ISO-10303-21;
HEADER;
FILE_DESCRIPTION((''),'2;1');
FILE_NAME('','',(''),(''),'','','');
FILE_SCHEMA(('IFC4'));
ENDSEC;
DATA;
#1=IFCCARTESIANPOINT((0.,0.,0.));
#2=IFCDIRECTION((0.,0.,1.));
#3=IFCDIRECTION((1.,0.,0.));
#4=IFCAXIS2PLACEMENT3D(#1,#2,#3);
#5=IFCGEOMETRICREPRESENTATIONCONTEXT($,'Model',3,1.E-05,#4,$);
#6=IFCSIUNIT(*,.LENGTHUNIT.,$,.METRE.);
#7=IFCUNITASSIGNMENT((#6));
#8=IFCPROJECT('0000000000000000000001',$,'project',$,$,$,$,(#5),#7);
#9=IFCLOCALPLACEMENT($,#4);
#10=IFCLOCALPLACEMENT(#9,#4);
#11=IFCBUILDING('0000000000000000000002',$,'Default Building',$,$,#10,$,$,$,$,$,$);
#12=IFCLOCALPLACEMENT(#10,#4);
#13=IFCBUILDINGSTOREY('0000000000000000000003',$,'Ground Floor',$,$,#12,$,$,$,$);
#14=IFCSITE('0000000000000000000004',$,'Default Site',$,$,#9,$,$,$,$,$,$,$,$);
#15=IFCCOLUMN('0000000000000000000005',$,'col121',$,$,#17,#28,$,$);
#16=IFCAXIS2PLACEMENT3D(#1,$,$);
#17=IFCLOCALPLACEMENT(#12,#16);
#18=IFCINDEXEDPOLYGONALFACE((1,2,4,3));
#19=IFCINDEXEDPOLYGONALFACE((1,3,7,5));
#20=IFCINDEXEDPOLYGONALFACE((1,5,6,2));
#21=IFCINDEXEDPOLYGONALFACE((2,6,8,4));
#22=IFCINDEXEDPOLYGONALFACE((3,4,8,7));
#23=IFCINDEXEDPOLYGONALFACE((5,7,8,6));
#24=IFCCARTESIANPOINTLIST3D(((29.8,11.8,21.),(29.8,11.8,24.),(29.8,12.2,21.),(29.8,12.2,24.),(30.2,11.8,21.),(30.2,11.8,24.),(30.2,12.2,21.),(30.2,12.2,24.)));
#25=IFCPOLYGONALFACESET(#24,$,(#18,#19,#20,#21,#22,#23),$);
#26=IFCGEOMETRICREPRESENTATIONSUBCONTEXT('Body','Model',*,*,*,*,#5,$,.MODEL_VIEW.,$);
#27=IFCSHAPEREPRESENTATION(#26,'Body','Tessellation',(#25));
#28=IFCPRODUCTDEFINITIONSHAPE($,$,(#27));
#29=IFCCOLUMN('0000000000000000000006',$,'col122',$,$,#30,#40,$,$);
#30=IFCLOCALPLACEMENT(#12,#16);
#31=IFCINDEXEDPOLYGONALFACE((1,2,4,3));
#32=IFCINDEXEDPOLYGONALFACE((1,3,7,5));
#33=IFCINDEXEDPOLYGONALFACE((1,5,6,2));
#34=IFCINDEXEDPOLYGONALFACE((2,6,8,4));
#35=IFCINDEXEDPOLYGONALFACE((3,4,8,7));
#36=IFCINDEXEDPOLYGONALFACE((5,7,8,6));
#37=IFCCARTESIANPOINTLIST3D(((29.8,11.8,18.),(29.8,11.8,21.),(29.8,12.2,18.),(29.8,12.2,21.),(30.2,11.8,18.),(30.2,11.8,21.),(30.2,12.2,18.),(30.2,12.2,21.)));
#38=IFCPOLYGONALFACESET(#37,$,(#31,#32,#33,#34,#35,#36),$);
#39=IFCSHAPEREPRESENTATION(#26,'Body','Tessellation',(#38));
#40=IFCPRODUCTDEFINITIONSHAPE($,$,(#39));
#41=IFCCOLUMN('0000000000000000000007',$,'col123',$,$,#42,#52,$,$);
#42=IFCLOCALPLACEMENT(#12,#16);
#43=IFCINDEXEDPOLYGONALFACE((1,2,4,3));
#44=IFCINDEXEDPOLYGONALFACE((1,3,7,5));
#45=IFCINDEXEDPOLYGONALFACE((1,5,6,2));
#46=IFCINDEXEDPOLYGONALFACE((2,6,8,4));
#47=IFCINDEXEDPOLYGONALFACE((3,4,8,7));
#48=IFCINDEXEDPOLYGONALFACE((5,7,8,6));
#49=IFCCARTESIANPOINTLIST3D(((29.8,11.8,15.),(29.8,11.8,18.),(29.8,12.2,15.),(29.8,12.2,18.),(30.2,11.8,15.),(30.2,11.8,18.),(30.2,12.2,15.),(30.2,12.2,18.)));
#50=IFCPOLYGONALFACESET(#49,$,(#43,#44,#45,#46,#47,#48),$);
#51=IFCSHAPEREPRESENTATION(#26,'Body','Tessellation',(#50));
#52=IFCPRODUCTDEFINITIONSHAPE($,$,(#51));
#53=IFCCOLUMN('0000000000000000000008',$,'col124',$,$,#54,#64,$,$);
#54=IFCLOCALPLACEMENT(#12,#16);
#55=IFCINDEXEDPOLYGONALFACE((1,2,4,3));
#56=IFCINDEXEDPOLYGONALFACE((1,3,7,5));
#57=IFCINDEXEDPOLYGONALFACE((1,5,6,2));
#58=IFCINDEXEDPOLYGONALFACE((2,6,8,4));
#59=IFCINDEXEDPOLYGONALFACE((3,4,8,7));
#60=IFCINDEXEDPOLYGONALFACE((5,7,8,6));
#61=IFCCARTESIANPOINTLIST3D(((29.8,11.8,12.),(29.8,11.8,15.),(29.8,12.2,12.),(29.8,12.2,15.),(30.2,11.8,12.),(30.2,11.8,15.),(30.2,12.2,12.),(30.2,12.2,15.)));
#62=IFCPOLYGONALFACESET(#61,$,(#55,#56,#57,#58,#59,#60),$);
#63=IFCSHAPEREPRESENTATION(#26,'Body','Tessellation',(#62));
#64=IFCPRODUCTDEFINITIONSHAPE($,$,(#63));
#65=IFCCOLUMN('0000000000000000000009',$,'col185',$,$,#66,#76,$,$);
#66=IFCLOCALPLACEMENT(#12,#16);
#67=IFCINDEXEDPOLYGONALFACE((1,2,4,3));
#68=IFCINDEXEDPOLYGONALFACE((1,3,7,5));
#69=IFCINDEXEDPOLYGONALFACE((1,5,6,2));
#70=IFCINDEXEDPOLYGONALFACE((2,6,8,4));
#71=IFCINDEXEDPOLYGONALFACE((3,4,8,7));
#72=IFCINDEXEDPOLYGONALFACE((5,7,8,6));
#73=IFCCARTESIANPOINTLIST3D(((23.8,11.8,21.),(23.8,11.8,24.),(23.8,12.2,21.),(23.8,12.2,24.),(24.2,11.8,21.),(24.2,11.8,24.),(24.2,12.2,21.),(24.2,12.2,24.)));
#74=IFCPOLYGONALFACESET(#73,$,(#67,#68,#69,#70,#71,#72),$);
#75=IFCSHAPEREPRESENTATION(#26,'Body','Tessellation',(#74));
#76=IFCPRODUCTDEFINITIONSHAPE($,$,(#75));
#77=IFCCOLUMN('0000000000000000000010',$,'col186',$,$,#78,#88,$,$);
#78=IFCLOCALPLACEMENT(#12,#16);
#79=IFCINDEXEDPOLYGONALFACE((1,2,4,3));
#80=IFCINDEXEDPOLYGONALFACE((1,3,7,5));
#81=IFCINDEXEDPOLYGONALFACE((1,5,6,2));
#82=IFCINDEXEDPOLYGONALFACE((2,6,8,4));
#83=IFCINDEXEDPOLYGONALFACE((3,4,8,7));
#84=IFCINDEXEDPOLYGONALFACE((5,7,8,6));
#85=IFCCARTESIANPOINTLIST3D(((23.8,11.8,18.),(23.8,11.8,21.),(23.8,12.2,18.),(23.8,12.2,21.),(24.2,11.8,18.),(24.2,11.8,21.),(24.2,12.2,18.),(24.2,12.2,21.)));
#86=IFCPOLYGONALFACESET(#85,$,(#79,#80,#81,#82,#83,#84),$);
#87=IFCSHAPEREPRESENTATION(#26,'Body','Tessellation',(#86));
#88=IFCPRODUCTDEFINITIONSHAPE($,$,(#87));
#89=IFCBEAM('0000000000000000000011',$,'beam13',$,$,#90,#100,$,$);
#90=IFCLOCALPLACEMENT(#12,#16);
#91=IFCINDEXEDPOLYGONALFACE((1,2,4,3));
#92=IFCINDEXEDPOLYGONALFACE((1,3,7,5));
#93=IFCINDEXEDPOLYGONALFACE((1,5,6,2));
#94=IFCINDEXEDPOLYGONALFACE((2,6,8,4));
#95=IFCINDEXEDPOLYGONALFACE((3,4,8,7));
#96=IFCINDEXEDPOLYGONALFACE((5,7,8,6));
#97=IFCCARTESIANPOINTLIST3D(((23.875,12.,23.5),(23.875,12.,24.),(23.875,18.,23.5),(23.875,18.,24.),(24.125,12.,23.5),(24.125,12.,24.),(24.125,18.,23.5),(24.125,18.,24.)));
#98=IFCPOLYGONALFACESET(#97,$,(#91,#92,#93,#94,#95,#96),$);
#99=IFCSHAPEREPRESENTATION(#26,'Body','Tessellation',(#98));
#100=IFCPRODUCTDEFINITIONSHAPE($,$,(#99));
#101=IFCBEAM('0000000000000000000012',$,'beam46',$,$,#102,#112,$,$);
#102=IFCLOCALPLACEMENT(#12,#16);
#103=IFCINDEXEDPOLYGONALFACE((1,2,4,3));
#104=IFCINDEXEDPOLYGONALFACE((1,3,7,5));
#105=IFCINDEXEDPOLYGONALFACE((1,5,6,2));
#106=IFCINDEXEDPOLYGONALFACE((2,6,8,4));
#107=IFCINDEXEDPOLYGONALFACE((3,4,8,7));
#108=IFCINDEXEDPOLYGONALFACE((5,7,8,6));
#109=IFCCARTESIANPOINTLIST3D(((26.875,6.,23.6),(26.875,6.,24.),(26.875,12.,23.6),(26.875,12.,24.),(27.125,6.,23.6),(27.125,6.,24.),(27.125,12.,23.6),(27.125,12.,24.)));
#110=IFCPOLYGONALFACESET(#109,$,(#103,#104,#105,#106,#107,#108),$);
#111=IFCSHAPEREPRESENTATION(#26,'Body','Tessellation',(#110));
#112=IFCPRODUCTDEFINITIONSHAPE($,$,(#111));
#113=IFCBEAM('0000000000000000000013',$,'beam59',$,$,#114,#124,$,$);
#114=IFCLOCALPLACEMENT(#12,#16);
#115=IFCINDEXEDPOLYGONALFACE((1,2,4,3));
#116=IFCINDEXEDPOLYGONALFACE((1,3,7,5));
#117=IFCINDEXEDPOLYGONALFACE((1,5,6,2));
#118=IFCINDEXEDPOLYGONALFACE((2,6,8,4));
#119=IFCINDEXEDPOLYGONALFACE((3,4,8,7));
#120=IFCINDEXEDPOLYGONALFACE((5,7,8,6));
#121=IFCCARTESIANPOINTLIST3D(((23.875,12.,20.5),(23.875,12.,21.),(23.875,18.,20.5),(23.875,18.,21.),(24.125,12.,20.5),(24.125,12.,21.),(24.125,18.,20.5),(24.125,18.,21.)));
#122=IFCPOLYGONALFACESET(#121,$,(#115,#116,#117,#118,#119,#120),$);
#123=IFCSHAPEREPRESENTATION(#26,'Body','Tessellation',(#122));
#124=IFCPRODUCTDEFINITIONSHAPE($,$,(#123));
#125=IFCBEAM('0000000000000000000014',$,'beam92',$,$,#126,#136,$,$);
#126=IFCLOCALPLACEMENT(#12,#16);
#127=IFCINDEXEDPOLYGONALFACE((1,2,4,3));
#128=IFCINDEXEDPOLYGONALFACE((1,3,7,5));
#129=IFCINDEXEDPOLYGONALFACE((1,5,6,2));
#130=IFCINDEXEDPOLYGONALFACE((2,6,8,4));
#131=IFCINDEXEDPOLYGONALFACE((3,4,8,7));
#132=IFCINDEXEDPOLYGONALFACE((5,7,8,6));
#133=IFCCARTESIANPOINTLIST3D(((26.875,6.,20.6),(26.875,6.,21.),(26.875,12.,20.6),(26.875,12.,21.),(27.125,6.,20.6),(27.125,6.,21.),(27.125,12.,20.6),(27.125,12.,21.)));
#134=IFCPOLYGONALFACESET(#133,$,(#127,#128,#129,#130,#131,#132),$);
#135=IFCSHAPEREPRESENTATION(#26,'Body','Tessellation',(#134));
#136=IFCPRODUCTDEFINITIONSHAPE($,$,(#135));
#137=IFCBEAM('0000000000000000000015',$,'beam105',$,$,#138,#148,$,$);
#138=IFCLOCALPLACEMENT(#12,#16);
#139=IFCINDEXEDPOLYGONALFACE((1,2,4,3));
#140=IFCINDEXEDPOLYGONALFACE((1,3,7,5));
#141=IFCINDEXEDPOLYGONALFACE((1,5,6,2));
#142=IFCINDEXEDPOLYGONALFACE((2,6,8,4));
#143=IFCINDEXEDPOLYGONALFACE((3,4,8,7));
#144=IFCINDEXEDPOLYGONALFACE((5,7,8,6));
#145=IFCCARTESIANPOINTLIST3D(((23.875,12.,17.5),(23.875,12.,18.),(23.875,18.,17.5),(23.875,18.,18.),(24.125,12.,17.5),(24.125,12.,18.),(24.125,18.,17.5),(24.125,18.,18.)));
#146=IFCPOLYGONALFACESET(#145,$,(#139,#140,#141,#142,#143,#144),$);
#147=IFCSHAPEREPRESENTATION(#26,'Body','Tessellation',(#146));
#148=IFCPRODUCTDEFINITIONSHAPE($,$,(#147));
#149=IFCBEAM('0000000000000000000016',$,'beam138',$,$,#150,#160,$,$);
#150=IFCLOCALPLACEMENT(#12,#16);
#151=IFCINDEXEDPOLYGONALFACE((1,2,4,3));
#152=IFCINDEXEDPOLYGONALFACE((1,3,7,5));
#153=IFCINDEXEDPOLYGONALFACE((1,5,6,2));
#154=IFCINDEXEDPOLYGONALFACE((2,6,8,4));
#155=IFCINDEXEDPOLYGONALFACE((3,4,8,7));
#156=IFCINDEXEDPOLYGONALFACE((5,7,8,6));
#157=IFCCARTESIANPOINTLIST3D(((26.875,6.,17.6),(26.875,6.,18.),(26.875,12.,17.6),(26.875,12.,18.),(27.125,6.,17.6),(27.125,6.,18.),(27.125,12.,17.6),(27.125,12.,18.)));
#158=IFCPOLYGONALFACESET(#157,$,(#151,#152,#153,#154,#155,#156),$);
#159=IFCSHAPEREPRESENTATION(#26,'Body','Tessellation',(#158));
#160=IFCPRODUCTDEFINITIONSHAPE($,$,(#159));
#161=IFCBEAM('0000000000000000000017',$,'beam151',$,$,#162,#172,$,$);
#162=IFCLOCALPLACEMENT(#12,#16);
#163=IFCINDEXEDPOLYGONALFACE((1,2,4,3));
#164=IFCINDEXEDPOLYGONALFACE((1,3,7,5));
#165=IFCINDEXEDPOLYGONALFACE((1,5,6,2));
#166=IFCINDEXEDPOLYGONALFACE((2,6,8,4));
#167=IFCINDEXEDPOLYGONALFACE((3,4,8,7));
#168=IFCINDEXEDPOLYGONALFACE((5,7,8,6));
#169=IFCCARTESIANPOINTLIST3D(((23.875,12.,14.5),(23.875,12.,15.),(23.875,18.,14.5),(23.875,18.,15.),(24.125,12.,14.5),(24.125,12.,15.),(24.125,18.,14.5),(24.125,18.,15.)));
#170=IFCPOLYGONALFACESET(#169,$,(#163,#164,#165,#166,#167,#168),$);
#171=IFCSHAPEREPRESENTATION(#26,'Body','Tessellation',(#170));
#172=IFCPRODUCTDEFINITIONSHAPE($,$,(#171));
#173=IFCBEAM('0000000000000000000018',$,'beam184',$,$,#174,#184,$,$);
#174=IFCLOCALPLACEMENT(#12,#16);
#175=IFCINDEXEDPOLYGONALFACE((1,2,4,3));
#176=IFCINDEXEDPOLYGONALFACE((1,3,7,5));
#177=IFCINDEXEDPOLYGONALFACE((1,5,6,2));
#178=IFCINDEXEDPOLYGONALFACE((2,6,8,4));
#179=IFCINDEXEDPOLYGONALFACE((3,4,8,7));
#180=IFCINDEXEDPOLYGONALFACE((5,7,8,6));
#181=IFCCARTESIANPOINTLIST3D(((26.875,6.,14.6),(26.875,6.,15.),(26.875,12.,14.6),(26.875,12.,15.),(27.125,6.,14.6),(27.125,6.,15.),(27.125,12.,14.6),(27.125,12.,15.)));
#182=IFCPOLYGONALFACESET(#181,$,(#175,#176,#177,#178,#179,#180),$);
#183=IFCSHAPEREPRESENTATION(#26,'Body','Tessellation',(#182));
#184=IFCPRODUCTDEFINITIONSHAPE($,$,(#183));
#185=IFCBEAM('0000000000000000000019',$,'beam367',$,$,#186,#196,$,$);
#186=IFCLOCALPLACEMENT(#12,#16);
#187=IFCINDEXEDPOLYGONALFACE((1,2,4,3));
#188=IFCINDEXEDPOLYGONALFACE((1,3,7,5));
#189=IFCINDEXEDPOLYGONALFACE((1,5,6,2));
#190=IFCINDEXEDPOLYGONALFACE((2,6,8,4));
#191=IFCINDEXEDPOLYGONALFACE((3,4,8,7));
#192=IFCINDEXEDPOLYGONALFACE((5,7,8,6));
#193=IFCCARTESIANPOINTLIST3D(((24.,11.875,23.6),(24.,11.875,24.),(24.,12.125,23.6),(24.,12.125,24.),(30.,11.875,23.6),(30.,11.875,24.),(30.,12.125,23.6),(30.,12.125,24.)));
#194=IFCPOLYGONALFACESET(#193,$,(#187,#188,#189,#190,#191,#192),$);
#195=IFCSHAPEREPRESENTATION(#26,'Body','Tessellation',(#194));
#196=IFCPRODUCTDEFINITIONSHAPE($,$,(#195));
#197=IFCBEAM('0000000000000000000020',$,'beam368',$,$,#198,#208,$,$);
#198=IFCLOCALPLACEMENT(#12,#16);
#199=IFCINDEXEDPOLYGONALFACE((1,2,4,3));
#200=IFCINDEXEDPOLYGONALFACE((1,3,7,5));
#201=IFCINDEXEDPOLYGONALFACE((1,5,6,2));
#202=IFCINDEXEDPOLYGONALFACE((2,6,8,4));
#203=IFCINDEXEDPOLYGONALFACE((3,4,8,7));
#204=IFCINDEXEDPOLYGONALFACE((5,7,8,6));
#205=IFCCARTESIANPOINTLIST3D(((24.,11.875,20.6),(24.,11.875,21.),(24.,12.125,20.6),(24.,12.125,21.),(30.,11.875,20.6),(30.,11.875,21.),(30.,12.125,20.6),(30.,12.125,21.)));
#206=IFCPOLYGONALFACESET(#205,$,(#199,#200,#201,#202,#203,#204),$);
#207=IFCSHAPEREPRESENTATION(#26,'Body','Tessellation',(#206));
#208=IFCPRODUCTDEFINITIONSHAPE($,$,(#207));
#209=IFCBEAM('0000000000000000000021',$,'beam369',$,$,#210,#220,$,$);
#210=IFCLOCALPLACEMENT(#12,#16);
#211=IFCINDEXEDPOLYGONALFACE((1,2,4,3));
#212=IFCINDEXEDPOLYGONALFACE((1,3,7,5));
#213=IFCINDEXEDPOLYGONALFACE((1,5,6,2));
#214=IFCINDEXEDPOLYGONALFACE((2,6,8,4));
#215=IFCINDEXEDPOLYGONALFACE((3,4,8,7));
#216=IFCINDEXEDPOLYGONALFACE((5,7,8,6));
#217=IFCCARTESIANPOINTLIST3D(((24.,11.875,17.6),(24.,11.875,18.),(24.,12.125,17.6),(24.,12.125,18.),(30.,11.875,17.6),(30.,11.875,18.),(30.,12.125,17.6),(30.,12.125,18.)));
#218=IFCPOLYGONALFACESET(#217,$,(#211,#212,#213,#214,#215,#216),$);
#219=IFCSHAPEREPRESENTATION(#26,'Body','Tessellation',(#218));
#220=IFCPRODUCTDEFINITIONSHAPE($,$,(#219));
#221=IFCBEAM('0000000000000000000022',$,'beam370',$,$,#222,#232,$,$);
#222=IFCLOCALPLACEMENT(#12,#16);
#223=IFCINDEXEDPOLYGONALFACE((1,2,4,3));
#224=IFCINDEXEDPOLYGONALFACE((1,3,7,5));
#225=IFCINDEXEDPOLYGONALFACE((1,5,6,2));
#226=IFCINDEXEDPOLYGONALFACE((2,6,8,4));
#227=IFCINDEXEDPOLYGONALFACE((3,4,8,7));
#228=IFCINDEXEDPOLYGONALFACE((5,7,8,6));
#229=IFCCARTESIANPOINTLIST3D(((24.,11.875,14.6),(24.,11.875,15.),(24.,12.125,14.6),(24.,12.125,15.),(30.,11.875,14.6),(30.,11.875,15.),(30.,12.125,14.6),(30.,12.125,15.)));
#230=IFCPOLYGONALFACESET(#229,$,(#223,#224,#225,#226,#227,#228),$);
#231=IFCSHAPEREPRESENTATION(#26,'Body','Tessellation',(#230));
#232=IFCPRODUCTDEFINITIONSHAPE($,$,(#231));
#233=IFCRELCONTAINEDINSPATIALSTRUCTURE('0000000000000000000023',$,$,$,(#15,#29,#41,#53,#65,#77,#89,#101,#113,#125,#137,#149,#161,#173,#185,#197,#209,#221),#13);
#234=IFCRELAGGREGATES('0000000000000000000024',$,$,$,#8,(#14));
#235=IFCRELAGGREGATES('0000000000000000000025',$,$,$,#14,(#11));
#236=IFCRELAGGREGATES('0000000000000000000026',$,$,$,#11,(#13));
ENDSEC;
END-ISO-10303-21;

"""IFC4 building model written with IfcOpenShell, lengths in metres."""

from ifc_helpers import new_model, si_unit, frame, origin_with_axes, place, context, subcontext, project, spatial, indexed_curve, outline, extrude, element, save


model = new_model("IFC4")

# Units and contexts
model_context = context("Model", 3, precision=1e-05, world=origin_with_axes())
body_context = subcontext(model_context, "Body", "Model", "MODEL_VIEW")
ifc_project = project(units=[si_unit("LENGTHUNIT", "METRE")], contexts=[model_context])

# Site, building, storey
site_placement = place(None, origin_with_axes())
site = spatial("IfcSite", under=ifc_project, at=site_placement, Name="Default Site")
building_placement = place(site_placement, origin_with_axes())
building = spatial("IfcBuilding", under=site, at=building_placement, Name="Default Building")
storey_placement = place(building_placement, origin_with_axes())
storey = spatial("IfcBuildingStorey", under=building, at=storey_placement, Name="Ground Floor")

# Columns
for number, where, z_axis, x_axis, name in (
    (1, (29.8, 11.8, 21.0), (0.0, 0.0, 1.0), (1.0, 0.0, 0.0), "col121"),
    (2, (29.8, 11.8, 18.0), (0.0, 0.0, 1.0), (1.0, 0.0, 0.0), "col122"),
    (3, (29.8, 11.8, 15.0), (0.0, 0.0, 1.0), (1.0, 0.0, 0.0), "col123"),
    (4, (29.8, 11.8, 12.0), (0.0, 0.0, 1.0), (1.0, 0.0, 0.0), "col124"),
    (5, (23.8, 11.8, 21.0), (0.0, 0.0, 1.0), (1.0, 0.0, 0.0), "col185"),
    (6, (23.8, 11.8, 18.0), (0.0, 0.0, 1.0), (1.0, 0.0, 0.0), "col186"),
):
    element("IfcColumn", number, at=place(storey_placement, frame(where, z_axis=z_axis, x_axis=x_axis)), inside=storey, Name=name, context=body_context, shape_type="SweptSolid", body=[
        extrude(outline(indexed_curve([(0.0, 0.0), (0.0, 0.4), (0.4, 0.4), (0.4, 0.0), (0.0, 0.0)], self_intersect=False)), origin_with_axes(), (0.0, 0.0, 1.0), 3.0),
    ])

# Beams
beam_1_placement = place(storey_placement, frame((24.125, 12.0, 23.5), z_axis=(0.0, 0.0, 1.0), x_axis=(0.0, 1.0, 0.0)))
element("IfcBeam", 7, at=beam_1_placement, inside=storey, Name="beam13", context=body_context, shape_type="SweptSolid", body=[
    extrude(outline(indexed_curve([(0.0, 0.0), (0.0, 0.25), (6.0, 0.25), (6.0, 0.0), (0.0, 0.0)], self_intersect=False)), origin_with_axes(), (0.0, 0.0, 1.0), 0.5),
])
beam_2_placement = place(storey_placement, frame((26.875, 12.0, 23.6), z_axis=(0.0, 0.0, 1.0), x_axis=(0.0, -1.0, 0.0)))
element("IfcBeam", 8, at=beam_2_placement, inside=storey, Name="beam46", context=body_context, shape_type="SweptSolid", body=[
    extrude(outline(indexed_curve([(0.0, 0.0), (0.0, 0.25), (6.0, 0.25), (6.0, 0.0), (0.0, 0.0)], self_intersect=False)), origin_with_axes(), (0.0, 0.0, 1.0), 0.4),
])
beam_3_placement = place(storey_placement, frame((24.125, 12.0, 20.5), z_axis=(0.0, 0.0, 1.0), x_axis=(0.0, 1.0, 0.0)))
element("IfcBeam", 9, at=beam_3_placement, inside=storey, Name="beam59", context=body_context, shape_type="SweptSolid", body=[
    extrude(outline(indexed_curve([(0.0, 0.0), (0.0, 0.25), (6.0, 0.25), (6.0, 0.0), (0.0, 0.0)], self_intersect=False)), origin_with_axes(), (0.0, 0.0, 1.0), 0.5),
])
beam_4_placement = place(storey_placement, frame((26.875, 12.0, 20.6), z_axis=(0.0, 0.0, 1.0), x_axis=(0.0, -1.0, 0.0)))
element("IfcBeam", 10, at=beam_4_placement, inside=storey, Name="beam92", context=body_context, shape_type="SweptSolid", body=[
    extrude(outline(indexed_curve([(0.0, 0.0), (0.0, 0.25), (6.0, 0.25), (6.0, 0.0), (0.0, 0.0)], self_intersect=False)), origin_with_axes(), (0.0, 0.0, 1.0), 0.4),
])
beam_5_placement = place(storey_placement, frame((24.125, 12.0, 17.5), z_axis=(0.0, 0.0, 1.0), x_axis=(0.0, 1.0, 0.0)))
element("IfcBeam", 11, at=beam_5_placement, inside=storey, Name="beam105", context=body_context, shape_type="SweptSolid", body=[
    extrude(outline(indexed_curve([(0.0, 0.0), (0.0, 0.25), (6.0, 0.25), (6.0, 0.0), (0.0, 0.0)], self_intersect=False)), origin_with_axes(), (0.0, 0.0, 1.0), 0.5),
])
beam_6_placement = place(storey_placement, frame((26.875, 12.0, 17.6), z_axis=(0.0, 0.0, 1.0), x_axis=(0.0, -1.0, 0.0)))
element("IfcBeam", 12, at=beam_6_placement, inside=storey, Name="beam138", context=body_context, shape_type="SweptSolid", body=[
    extrude(outline(indexed_curve([(0.0, 0.0), (0.0, 0.25), (6.0, 0.25), (6.0, 0.0), (0.0, 0.0)], self_intersect=False)), origin_with_axes(), (0.0, 0.0, 1.0), 0.4),
])
beam_7_placement = place(storey_placement, frame((24.125, 12.0, 14.5), z_axis=(0.0, 0.0, 1.0), x_axis=(0.0, 1.0, 0.0)))
element("IfcBeam", 13, at=beam_7_placement, inside=storey, Name="beam151", context=body_context, shape_type="SweptSolid", body=[
    extrude(outline(indexed_curve([(0.0, 0.0), (0.0, 0.25), (6.0, 0.25), (6.0, 0.0), (0.0, 0.0)], self_intersect=False)), origin_with_axes(), (0.0, 0.0, 1.0), 0.5),
])
for number, where, z_axis, x_axis, name in (
    (14, (26.875, 12.0, 14.6), (0.0, 0.0, 1.0), (0.0, -1.0, 0.0), "beam184"),
    (15, (24.0, 11.875, 23.6), (0.0, 0.0, 1.0), (1.0, 0.0, 0.0), "beam367"),
    (16, (24.0, 11.875, 20.6), (0.0, 0.0, 1.0), (1.0, 0.0, 0.0), "beam368"),
    (17, (24.0, 11.875, 17.6), (0.0, 0.0, 1.0), (1.0, 0.0, 0.0), "beam369"),
    (18, (24.0, 11.875, 14.6), (0.0, 0.0, 1.0), (1.0, 0.0, 0.0), "beam370"),
):
    element("IfcBeam", number, at=place(storey_placement, frame(where, z_axis=z_axis, x_axis=x_axis)), inside=storey, Name=name, context=body_context, shape_type="SweptSolid", body=[
        extrude(outline(indexed_curve([(0.0, 0.0), (0.0, 0.25), (6.0, 0.25), (6.0, 0.0), (0.0, 0.0)], self_intersect=False)), origin_with_axes(), (0.0, 0.0, 1.0), 0.4),
    ])

save(model, "model.ifc")
